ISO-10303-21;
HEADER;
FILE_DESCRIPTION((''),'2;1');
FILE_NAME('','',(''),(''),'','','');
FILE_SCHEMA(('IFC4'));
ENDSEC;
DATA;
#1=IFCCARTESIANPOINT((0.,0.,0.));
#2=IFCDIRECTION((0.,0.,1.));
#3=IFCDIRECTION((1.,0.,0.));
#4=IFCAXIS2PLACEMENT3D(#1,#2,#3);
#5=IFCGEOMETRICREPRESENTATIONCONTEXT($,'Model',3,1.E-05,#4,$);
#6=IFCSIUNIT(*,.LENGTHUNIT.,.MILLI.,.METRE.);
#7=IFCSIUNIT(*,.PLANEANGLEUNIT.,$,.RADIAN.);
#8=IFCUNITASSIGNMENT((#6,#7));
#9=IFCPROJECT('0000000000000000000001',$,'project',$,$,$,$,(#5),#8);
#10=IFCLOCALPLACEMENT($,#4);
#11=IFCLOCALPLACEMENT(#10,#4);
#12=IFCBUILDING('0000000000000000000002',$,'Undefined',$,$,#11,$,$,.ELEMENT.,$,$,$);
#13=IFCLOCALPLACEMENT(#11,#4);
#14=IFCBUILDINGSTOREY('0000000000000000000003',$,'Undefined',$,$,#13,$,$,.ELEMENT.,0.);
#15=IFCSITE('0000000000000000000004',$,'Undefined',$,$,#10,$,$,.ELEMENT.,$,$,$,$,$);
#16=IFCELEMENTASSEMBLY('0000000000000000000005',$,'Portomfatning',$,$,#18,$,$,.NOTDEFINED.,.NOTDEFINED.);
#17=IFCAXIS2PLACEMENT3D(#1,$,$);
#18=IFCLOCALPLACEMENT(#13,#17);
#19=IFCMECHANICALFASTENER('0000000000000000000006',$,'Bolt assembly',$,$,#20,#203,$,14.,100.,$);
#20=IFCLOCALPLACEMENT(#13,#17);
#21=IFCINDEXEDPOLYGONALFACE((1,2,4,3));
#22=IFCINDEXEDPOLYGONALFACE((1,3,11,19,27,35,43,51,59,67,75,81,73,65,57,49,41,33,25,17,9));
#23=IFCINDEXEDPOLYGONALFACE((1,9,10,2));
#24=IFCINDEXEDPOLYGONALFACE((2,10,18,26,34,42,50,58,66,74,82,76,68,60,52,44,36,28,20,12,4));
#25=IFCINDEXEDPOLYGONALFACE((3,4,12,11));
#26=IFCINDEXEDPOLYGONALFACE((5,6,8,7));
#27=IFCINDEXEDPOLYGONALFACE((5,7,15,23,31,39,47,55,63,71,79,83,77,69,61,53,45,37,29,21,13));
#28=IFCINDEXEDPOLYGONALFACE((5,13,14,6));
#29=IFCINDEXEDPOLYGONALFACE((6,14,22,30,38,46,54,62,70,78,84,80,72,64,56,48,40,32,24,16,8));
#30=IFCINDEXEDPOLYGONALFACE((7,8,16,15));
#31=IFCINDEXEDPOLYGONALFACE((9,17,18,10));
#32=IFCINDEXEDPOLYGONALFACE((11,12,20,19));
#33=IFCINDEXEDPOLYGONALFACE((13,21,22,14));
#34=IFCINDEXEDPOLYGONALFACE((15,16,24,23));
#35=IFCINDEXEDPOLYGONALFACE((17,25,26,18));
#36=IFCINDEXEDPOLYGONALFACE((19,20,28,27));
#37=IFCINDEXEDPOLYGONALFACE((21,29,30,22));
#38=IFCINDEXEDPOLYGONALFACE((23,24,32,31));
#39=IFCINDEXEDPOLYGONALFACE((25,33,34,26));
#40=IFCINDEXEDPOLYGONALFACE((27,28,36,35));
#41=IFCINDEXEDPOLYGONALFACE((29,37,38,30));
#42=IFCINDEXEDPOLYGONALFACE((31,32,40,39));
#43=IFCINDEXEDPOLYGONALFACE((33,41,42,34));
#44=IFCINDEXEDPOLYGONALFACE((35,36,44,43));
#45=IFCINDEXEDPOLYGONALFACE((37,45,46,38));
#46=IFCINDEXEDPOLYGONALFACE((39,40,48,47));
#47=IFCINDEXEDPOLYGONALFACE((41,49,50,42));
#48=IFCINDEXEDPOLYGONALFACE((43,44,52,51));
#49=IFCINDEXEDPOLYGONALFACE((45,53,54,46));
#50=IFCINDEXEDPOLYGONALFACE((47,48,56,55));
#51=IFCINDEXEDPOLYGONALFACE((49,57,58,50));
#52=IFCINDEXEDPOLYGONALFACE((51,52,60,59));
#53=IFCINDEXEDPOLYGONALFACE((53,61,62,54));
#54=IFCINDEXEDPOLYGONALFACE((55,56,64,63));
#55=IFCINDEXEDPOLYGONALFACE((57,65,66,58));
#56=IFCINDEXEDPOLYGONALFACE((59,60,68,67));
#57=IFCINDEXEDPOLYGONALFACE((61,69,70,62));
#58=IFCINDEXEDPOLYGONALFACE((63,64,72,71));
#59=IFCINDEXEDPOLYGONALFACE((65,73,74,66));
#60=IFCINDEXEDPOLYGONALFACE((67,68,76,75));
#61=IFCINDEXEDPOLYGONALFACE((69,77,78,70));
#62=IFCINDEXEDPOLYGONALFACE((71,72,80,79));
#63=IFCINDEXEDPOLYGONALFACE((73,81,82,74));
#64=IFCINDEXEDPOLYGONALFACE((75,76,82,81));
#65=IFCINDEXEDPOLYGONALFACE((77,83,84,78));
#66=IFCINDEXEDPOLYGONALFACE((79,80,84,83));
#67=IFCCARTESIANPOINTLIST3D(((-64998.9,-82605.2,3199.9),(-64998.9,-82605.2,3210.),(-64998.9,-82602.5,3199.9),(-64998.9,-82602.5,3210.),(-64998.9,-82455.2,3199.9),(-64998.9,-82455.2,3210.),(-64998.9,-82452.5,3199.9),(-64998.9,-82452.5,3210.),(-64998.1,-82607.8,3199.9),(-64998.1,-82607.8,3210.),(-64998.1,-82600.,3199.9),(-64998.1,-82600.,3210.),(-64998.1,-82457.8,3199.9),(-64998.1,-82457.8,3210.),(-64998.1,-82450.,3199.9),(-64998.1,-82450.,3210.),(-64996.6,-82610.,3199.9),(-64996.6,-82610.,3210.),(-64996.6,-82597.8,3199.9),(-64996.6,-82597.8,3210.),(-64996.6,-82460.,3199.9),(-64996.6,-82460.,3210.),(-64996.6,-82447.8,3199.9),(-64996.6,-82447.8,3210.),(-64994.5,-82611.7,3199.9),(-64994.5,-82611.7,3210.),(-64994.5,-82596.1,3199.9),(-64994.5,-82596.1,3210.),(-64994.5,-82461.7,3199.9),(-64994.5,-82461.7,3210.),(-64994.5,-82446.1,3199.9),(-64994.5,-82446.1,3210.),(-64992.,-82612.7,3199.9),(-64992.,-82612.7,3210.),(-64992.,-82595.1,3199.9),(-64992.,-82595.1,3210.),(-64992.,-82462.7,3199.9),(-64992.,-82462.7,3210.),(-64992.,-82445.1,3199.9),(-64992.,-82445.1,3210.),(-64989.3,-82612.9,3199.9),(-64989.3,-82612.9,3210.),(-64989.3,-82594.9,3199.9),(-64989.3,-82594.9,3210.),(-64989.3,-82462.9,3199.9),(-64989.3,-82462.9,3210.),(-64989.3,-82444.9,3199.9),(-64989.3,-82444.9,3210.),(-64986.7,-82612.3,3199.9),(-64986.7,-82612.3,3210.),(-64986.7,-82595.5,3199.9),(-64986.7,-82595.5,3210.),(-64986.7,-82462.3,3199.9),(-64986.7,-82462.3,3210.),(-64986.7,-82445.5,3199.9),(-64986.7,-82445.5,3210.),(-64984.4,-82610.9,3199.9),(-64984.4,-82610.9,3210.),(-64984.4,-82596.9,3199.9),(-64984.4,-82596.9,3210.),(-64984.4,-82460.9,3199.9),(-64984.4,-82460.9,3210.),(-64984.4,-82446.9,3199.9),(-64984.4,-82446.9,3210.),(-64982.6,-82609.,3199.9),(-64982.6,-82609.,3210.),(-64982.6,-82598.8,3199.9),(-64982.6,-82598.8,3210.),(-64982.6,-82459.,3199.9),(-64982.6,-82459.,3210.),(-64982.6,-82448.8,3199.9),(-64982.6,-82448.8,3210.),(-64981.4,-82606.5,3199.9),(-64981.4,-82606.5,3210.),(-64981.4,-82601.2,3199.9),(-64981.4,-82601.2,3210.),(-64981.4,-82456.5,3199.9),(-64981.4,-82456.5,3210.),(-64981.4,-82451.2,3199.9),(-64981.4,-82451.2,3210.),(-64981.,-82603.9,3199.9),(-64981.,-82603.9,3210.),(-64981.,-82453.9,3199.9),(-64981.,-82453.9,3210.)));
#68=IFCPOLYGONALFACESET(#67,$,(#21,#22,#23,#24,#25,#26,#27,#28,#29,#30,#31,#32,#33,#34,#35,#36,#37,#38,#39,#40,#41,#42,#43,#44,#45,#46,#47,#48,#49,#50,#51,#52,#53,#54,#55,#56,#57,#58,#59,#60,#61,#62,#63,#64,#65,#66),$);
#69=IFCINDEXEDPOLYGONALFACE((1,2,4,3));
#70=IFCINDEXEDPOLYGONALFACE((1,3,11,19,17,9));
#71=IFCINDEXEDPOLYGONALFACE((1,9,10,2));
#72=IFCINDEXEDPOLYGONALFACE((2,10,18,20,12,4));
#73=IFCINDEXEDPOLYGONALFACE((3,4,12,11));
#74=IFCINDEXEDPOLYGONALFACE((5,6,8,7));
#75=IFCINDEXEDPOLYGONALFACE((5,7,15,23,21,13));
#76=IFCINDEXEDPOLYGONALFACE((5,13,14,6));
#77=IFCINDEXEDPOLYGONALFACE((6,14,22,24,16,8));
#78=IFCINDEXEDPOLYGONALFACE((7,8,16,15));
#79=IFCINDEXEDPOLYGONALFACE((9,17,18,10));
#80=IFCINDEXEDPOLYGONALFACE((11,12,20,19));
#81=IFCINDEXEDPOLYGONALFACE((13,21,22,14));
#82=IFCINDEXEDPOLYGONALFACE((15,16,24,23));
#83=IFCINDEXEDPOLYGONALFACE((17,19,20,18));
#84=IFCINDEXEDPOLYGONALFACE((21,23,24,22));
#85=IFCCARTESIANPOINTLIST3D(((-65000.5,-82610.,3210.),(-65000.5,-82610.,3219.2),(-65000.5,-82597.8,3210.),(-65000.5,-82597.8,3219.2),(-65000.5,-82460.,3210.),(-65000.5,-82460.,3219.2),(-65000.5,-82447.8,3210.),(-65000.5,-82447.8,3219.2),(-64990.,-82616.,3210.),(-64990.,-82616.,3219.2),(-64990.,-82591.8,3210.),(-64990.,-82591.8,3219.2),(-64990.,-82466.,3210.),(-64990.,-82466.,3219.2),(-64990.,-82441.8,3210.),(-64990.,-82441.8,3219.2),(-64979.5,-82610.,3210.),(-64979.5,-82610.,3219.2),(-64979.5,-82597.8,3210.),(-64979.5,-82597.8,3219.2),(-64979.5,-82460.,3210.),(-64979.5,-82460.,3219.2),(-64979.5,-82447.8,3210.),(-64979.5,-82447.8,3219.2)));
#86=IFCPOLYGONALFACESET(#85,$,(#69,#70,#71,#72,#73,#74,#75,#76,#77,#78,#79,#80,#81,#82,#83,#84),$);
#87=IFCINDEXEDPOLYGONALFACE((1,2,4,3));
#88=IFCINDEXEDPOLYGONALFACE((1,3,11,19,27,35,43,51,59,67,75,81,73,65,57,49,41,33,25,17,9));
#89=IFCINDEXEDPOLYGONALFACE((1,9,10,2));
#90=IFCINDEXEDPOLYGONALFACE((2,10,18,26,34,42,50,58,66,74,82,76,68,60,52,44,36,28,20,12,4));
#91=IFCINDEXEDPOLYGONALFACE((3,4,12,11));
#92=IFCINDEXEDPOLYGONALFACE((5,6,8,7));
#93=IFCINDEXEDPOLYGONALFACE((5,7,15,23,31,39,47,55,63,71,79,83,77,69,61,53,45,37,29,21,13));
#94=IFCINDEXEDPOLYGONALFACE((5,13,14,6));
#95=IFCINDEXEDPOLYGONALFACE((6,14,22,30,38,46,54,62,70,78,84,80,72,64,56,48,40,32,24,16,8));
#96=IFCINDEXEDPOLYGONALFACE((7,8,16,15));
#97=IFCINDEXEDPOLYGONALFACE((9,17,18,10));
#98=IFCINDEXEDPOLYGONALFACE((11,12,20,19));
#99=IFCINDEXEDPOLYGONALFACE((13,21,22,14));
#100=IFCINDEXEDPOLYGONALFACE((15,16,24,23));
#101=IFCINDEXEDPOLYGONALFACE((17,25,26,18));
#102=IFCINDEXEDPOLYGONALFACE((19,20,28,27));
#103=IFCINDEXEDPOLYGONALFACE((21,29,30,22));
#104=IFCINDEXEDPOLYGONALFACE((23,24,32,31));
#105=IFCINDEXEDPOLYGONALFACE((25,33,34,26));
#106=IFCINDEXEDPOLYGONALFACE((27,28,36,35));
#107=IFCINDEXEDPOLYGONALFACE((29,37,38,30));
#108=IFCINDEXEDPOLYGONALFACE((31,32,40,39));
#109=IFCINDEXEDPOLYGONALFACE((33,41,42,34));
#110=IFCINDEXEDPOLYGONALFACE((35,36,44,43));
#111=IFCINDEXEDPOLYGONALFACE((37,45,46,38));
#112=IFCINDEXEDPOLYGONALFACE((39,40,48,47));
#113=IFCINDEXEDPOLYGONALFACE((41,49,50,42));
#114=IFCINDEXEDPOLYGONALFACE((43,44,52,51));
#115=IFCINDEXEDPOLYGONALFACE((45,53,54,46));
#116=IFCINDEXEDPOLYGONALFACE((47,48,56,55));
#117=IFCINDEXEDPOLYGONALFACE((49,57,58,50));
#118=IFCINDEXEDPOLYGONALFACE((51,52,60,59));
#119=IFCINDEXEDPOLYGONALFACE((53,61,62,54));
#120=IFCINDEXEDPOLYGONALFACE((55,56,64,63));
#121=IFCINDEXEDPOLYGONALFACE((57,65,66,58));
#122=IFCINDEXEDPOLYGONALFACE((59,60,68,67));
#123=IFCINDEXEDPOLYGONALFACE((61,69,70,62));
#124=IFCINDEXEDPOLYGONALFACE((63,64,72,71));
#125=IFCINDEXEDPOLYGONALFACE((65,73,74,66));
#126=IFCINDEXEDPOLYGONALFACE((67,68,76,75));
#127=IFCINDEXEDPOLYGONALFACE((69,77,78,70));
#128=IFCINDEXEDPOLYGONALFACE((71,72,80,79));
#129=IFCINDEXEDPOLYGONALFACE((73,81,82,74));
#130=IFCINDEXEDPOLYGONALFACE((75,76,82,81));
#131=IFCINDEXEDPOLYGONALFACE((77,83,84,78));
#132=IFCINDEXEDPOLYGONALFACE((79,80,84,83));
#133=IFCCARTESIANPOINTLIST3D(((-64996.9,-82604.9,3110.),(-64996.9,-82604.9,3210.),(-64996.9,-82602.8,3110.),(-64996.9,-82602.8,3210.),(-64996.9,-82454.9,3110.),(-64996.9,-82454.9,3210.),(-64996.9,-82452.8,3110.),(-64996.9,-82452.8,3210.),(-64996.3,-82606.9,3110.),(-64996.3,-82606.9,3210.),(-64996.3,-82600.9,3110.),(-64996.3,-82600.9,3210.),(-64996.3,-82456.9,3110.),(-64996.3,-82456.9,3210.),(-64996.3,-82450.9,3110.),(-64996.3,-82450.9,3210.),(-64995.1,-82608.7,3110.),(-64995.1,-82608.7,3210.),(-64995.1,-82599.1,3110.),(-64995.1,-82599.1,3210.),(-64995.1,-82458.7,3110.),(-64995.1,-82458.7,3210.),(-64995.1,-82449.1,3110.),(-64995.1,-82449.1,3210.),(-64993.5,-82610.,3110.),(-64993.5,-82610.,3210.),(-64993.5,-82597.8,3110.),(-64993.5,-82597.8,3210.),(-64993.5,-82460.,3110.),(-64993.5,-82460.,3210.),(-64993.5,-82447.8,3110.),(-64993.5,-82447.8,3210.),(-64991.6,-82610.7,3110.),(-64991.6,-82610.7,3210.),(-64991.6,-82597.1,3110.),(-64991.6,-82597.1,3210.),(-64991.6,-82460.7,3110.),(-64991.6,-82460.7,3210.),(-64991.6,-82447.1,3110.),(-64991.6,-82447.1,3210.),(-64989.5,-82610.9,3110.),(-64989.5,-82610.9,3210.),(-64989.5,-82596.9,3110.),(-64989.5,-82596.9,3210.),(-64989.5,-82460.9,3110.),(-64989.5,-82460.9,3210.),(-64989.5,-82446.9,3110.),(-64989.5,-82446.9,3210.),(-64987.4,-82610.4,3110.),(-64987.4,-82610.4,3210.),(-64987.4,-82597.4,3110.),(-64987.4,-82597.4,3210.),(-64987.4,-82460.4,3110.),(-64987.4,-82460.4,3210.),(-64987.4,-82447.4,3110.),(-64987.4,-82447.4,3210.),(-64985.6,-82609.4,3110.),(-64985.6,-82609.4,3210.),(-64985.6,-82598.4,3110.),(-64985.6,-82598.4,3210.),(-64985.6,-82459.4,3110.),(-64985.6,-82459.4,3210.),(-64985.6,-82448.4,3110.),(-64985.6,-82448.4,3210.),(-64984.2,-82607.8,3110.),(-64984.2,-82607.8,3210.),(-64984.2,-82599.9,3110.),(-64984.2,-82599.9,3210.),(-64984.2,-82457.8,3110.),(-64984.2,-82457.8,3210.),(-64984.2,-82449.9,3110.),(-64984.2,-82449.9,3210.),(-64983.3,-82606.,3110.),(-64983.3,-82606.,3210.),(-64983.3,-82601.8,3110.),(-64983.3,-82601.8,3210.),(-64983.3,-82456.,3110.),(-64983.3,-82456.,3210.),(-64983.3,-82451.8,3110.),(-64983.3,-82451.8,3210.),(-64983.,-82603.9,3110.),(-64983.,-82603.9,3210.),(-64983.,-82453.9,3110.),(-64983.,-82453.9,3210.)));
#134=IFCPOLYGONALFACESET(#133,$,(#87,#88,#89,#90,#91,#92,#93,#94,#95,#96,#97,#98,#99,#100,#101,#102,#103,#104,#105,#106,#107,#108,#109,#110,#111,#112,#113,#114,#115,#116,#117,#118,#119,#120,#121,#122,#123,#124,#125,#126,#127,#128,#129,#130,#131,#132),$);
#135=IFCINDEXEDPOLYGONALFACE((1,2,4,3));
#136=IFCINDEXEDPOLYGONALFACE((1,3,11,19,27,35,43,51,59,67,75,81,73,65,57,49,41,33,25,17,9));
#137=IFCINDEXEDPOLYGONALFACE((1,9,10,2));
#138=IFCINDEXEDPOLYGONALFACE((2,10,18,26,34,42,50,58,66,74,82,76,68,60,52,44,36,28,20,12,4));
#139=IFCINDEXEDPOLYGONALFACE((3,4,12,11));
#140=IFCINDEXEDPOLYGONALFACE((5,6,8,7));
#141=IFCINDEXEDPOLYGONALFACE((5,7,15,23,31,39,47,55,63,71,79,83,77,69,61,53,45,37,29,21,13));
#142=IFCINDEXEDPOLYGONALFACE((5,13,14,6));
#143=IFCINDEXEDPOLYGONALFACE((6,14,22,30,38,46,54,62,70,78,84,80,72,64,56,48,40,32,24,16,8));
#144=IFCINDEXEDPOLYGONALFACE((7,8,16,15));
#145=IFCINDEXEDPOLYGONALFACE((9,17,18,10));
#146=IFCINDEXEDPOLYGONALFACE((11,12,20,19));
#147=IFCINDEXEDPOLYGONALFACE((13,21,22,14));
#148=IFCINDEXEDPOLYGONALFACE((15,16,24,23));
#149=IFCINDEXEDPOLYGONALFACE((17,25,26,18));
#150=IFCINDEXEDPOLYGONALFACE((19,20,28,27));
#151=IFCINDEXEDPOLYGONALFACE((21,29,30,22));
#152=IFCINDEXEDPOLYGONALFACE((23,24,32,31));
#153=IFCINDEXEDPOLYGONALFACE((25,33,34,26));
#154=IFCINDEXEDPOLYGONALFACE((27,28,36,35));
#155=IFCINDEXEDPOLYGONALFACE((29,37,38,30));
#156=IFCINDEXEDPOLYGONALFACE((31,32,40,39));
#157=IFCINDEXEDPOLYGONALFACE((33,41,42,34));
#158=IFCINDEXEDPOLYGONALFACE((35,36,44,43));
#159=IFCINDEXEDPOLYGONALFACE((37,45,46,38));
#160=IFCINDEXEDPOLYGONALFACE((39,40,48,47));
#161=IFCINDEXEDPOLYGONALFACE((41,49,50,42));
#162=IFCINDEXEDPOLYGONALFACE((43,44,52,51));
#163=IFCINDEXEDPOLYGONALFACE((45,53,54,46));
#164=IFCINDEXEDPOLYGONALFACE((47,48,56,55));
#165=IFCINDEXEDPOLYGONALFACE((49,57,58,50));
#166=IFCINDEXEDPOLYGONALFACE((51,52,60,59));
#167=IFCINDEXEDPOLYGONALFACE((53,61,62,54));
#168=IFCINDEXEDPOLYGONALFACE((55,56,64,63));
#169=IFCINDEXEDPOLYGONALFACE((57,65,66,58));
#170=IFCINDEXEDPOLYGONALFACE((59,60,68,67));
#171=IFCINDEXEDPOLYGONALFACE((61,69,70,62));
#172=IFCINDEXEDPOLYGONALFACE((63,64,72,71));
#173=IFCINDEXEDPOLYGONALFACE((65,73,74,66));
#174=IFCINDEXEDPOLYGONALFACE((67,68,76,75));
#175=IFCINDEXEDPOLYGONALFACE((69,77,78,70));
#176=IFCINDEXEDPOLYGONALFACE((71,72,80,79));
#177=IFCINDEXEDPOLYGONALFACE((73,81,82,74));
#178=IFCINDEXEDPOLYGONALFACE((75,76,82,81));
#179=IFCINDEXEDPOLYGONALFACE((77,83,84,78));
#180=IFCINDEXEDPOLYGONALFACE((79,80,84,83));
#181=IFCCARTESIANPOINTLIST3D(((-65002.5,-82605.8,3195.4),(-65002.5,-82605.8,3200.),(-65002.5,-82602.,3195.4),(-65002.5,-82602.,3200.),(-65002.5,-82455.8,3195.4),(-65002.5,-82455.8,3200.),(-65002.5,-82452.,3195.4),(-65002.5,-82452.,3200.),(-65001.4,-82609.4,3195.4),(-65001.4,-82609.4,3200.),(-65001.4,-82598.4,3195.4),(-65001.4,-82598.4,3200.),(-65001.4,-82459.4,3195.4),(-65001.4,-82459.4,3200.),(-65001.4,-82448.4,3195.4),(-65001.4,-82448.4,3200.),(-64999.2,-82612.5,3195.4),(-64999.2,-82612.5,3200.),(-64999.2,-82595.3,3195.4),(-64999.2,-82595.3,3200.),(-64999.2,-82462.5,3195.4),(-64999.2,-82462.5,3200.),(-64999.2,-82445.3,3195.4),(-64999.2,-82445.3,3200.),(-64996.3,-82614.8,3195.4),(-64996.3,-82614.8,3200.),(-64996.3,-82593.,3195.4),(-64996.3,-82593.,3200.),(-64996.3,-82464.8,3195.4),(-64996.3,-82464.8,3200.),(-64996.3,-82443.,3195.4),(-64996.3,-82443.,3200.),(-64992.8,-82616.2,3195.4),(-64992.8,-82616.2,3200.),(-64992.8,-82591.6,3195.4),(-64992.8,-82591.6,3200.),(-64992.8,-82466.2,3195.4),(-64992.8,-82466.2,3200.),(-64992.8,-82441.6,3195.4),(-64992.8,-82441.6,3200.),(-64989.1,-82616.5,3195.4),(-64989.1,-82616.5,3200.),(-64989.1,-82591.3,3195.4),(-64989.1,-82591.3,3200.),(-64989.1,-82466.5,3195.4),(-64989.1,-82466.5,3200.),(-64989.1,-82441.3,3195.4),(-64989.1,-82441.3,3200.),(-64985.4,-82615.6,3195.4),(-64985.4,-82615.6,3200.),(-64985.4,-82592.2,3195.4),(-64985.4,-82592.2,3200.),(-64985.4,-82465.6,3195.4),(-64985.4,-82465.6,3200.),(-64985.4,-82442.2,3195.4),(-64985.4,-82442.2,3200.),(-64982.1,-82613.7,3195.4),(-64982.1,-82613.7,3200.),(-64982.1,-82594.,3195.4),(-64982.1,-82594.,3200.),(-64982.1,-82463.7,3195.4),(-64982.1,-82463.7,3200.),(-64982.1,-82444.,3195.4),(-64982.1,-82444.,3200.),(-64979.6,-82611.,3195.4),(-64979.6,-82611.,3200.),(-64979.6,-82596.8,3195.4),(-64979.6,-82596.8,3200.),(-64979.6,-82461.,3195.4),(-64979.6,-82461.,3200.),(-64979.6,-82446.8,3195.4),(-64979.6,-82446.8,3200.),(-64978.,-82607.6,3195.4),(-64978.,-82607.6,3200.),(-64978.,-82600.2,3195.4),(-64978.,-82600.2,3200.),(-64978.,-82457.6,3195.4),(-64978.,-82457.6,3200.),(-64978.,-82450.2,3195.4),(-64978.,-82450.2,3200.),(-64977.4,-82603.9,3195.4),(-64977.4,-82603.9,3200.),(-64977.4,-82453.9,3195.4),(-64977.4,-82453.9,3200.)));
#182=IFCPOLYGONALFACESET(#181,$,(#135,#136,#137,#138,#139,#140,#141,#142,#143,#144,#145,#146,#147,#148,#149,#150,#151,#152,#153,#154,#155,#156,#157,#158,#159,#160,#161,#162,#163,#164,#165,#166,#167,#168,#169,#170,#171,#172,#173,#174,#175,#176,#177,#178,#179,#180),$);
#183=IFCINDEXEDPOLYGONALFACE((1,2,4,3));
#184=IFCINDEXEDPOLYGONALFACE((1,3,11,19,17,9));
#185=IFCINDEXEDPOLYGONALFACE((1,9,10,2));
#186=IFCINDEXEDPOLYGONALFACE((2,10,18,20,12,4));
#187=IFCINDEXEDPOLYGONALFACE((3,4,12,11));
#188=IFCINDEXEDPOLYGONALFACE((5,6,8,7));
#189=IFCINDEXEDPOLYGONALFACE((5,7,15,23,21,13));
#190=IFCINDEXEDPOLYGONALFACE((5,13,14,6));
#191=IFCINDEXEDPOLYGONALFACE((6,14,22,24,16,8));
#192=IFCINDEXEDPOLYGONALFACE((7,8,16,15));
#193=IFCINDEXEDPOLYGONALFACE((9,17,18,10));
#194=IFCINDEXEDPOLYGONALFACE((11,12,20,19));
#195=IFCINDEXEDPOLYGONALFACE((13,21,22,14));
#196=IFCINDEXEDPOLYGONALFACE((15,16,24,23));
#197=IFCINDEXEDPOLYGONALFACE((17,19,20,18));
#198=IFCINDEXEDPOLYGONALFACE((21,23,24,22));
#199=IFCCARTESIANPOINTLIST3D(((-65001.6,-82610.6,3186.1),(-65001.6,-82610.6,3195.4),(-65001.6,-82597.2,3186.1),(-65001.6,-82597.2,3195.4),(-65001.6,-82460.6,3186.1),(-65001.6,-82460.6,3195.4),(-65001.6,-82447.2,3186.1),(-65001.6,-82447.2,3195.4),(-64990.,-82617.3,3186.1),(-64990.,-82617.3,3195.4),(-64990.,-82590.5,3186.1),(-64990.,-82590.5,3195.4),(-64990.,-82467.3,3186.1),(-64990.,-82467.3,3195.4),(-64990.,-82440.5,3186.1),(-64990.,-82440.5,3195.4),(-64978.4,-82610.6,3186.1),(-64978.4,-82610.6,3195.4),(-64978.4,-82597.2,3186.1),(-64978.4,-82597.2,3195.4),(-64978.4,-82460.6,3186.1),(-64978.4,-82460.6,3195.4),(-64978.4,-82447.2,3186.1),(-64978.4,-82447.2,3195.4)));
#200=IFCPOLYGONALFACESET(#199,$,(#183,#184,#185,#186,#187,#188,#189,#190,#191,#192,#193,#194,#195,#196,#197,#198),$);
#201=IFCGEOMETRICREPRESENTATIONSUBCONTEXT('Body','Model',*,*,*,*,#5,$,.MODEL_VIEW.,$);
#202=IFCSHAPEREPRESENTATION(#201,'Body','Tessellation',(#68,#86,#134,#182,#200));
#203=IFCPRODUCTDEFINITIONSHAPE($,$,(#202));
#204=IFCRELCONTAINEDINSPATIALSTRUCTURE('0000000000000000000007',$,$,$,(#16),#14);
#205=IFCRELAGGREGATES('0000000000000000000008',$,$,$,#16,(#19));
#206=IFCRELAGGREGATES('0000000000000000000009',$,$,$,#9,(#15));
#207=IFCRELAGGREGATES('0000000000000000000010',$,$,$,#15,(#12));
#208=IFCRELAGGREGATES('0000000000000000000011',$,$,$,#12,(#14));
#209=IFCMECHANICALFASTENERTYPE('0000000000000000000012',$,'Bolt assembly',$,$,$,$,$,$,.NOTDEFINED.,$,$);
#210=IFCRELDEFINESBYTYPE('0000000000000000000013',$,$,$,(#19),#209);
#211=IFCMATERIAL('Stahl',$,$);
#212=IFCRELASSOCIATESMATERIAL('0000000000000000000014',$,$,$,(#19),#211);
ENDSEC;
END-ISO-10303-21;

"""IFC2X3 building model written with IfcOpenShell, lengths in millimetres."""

from ifc_helpers import new_model, si_unit, frame, origin_with_axes, origin_2d_with_axis, place, context, subcontext, project, spatial, polyline, circle, outline, extrude, source, transform, mapped, material, type_object, element, aggregate, save


model = new_model("IFC2X3")

# Units and contexts
model_context = context("Model", 3, precision=1e-05, world=origin_with_axes())
body_context = subcontext(model_context, "Body", "Model", "MODEL_VIEW")
ifc_project = project(units=[si_unit("LENGTHUNIT", "METRE", prefix="MILLI"), si_unit("PLANEANGLEUNIT", "RADIAN")], contexts=[model_context])

# Site, building, storey
site_placement = place(None, origin_with_axes())
site = spatial("IfcSite", under=ifc_project, at=site_placement, Name="Undefined", CompositionType="ELEMENT")
building_placement = place(site_placement, origin_with_axes())
building = spatial("IfcBuilding", under=site, at=building_placement, Name="Undefined", CompositionType="ELEMENT")
storey_placement = place(building_placement, origin_with_axes())
storey = spatial("IfcBuildingStorey", under=building, at=storey_placement, Name="Undefined", CompositionType="ELEMENT", Elevation=0.0)

# Element assembly
assembly_1_placement = place(storey_placement, origin_with_axes())
assembly_1 = element("IfcElementAssembly", 1, at=assembly_1_placement, inside=storey, Name="Portomfatning", AssemblyPlace="NOTDEFINED", PredefinedType="NOTDEFINED")

# Mechanical fastener
mechanical_fastener_type = type_object("IfcMechanicalFastenerType", Name="Bolt assembly")
ifc_material_1 = material(Name="Stahl")
shared_shape_1 = source(origin_with_axes(), body_context, "Body", "SweptSolid", [
    extrude(circle(Radius=9.0, at=origin_2d_with_axis()), frame((0.0, 0.0, 0.0), z_axis=(0.0, 1.0, 0.0), x_axis=(1.0, 0.0, 0.0)), (0.0, 0.0, 1.0), 10.1),
    extrude(outline(polyline([(10.5, -6.1), (10.5, 6.1), (0.0, 12.1), (-10.5, 6.1), (-10.5, -6.1), (0.0, -12.1), (10.5, -6.1)])), frame((0.0, -9.2, 0.0), z_axis=(0.0, 1.0, 0.0), x_axis=(1.0, 0.0, 0.0)), (0.0, 0.0, 1.0), 9.2),
    extrude(circle(Radius=7.0, at=origin_2d_with_axis()), frame((0.0, 0.0, 0.0), z_axis=(0.0, 1.0, 0.0), x_axis=(1.0, 0.0, 0.0)), (0.0, 0.0, 1.0), 100.0),
    extrude(circle(Radius=12.6, at=origin_2d_with_axis()), frame((0.0, 10.0, 0.0), z_axis=(0.0, 1.0, 0.0), x_axis=(1.0, 0.0, 0.0)), (0.0, 0.0, 1.0), 4.6),
    extrude(outline(polyline([(11.6, -6.7), (11.6, 6.7), (0.0, 13.4), (-11.6, 6.7), (-11.6, -6.7), (0.0, -13.4), (11.6, -6.7)])), frame((0.0, 14.6, 0.0), z_axis=(0.0, 1.0, 0.0), x_axis=(1.0, 0.0, 0.0)), (0.0, 0.0, 1.0), 9.2),
])
mechanical_fastener_1_placement = place(assembly_1_placement, frame((-64990.0, -82528.9, 3210.0), z_axis=(0.0, 1.0, 0.0), x_axis=(1.0, 0.0, 0.0)))
mechanical_fastener_1 = element("IfcMechanicalFastener", 2, at=mechanical_fastener_1_placement, type_object=mechanical_fastener_type, material=ifc_material_1, Name="Bolt assembly", NominalDiameter=14.0, NominalLength=100.0, context=body_context, shape_type="MappedRepresentation", body=[
    mapped(shared_shape_1, transform((0.0, 0.0, -75.0))),
    mapped(shared_shape_1, transform((0.0, 0.0, 75.0))),
])
aggregate(assembly_1, [mechanical_fastener_1])

save(model, "model.ifc")
